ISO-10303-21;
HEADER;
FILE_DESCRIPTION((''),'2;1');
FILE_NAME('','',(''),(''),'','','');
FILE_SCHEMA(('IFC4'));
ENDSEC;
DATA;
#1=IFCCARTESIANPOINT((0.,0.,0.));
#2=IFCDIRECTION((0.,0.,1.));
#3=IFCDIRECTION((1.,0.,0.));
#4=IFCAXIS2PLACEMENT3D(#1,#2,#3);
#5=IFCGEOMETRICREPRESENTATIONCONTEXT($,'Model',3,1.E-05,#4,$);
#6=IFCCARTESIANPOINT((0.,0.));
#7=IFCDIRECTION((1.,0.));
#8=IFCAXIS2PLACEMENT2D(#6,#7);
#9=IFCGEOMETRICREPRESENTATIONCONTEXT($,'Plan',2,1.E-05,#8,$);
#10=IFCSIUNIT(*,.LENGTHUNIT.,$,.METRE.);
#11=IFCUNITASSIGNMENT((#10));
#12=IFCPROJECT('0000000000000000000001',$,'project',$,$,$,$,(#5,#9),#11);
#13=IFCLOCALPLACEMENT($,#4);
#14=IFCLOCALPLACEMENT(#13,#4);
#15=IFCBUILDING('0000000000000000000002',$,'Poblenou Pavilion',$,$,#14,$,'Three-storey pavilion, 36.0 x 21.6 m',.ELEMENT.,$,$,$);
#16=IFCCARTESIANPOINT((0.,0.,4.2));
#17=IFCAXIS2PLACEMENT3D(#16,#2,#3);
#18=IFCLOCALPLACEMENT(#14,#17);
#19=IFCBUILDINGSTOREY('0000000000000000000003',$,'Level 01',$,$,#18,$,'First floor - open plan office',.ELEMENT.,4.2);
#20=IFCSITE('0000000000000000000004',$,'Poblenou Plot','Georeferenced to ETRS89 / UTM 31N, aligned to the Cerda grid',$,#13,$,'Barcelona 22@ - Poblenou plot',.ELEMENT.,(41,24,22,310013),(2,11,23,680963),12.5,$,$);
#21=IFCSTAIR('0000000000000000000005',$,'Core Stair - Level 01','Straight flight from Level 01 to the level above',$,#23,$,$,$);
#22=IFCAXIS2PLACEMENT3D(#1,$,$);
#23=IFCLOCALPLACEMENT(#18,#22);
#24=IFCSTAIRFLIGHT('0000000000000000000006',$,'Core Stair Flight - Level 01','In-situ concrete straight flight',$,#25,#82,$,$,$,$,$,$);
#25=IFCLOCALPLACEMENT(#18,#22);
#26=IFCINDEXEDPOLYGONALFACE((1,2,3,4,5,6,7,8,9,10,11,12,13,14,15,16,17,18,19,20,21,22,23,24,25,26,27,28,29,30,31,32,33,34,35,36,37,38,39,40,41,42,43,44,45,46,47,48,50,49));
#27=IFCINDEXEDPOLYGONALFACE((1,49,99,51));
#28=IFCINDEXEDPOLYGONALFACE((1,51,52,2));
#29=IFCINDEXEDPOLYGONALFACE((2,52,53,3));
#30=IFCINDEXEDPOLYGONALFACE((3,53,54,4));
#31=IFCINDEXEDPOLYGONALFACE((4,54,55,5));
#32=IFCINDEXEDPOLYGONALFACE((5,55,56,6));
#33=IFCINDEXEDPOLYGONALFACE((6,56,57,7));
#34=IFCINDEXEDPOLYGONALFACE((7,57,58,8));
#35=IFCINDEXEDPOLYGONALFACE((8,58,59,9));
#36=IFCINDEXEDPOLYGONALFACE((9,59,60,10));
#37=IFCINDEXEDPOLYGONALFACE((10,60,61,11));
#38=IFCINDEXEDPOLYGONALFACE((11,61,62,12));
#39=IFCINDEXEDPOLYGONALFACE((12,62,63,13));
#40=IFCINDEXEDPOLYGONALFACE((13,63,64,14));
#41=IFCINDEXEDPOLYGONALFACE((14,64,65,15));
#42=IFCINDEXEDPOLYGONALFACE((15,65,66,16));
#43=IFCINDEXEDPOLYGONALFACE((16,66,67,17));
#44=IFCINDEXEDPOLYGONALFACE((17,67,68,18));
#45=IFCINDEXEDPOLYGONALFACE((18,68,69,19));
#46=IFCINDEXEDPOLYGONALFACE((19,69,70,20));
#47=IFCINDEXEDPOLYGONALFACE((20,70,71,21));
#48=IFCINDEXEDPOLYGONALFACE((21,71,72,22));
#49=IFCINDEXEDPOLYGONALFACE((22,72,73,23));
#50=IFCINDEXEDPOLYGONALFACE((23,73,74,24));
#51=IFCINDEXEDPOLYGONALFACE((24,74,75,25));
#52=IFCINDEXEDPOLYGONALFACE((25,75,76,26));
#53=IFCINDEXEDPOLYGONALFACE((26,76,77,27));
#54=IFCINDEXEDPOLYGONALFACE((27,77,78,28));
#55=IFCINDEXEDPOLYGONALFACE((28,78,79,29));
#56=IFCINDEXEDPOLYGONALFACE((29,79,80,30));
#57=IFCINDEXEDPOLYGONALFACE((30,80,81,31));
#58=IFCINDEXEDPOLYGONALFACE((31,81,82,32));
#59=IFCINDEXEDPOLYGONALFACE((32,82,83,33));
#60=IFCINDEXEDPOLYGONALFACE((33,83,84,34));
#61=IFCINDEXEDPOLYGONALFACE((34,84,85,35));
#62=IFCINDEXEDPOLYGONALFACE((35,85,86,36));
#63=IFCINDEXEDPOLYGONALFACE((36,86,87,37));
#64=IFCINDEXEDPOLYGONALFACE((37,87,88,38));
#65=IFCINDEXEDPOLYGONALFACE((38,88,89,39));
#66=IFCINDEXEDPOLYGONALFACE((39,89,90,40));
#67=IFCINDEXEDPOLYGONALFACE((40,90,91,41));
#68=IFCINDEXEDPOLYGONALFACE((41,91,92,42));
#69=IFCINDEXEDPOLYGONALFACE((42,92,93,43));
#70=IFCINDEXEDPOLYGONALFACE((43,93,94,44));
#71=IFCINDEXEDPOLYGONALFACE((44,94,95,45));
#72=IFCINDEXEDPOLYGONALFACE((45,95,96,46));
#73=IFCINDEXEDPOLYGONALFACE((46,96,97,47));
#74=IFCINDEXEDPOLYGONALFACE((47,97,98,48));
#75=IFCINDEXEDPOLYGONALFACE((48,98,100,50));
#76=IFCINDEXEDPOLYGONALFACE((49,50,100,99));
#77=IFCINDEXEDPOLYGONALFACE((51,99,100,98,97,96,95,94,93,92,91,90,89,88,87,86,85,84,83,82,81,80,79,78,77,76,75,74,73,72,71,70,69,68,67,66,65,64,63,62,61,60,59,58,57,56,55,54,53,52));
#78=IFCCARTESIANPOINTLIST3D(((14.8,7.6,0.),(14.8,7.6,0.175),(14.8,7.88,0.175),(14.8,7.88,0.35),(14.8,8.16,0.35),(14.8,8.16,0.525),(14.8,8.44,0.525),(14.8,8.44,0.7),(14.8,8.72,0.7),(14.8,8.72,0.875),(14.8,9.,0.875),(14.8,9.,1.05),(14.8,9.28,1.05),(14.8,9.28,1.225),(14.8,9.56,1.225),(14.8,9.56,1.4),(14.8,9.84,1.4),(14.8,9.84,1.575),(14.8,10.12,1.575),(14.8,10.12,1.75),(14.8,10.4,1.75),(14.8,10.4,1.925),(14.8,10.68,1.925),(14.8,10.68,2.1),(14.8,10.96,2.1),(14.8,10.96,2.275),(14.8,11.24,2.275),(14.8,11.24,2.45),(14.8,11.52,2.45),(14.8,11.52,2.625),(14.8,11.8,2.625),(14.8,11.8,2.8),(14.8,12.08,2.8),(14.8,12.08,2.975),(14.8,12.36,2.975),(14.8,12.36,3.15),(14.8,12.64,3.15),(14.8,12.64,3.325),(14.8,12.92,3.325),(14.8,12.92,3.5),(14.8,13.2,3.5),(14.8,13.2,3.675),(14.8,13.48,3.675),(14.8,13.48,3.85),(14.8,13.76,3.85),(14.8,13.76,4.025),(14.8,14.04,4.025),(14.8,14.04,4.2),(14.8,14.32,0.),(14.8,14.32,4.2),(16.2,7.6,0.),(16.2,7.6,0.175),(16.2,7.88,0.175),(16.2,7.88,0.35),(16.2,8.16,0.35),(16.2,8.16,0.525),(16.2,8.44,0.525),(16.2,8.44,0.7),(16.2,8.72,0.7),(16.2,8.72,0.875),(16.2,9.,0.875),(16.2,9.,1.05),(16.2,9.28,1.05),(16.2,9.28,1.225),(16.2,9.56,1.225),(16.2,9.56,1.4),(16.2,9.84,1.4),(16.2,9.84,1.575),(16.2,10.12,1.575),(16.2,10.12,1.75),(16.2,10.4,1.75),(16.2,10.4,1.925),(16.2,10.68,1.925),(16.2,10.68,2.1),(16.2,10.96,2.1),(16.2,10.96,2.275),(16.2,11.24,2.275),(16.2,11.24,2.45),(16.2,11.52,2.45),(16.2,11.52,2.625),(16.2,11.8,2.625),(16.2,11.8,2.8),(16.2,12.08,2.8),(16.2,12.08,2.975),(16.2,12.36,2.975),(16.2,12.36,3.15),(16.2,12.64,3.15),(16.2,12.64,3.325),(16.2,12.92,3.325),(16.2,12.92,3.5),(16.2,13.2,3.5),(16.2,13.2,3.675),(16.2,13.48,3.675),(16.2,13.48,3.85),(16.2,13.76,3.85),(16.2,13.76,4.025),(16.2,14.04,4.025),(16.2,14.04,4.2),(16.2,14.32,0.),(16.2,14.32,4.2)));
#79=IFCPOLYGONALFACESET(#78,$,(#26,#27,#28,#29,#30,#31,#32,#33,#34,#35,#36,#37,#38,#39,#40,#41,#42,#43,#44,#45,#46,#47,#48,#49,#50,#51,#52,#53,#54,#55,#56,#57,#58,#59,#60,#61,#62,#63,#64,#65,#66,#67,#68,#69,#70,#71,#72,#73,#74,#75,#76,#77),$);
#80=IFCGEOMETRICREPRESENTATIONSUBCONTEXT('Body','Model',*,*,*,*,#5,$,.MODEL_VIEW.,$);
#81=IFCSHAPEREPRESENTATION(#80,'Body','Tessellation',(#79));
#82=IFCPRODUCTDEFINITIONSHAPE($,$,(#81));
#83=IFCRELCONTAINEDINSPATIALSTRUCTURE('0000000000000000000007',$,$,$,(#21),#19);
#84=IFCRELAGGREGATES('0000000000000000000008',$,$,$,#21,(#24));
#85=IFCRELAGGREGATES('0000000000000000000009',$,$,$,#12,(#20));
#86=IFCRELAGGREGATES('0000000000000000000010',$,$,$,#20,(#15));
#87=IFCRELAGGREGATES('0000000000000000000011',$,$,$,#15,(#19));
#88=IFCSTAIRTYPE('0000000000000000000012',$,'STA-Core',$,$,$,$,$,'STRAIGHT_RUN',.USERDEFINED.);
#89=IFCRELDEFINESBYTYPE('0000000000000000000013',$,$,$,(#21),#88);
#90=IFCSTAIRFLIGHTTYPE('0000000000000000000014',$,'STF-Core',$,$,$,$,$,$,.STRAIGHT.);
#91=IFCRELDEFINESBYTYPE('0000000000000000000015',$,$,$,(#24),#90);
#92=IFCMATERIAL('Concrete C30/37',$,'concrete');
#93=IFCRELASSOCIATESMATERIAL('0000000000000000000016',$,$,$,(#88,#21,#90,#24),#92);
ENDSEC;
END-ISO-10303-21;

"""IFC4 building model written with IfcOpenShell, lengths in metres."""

from ifc_helpers import new_model, si_unit, frame, origin_with_axes, origin_2d_with_axis, place, context, subcontext, project, spatial, line, indexed_curve, outline, extrude, material, type_object, element, aggregate, save


model = new_model("IFC4")

# Units and contexts
model_context = context("Model", 3, precision=1e-05, world=origin_with_axes())
plan_context = context("Plan", 2, precision=1e-05, world=origin_2d_with_axis())
body_context = subcontext(model_context, "Body", "Model", "MODEL_VIEW")
ifc_project = project(units=[si_unit("LENGTHUNIT", "METRE")], contexts=[model_context, plan_context])

# Site, building, storey
site_placement = place(None, origin_with_axes())
site = spatial("IfcSite", under=ifc_project, at=site_placement, Name="Poblenou Plot", Description="Georeferenced to ETRS89 / UTM 31N, aligned to the Cerda grid", LongName="Barcelona 22@ - Poblenou plot", CompositionType="ELEMENT", RefLatitude=(41, 24, 22, 310013), RefLongitude=(2, 11, 23, 680963), RefElevation=12.5)
building_placement = place(site_placement, origin_with_axes())
building = spatial("IfcBuilding", under=site, at=building_placement, Name="Poblenou Pavilion", LongName="Three-storey pavilion, 36.0 x 21.6 m", CompositionType="ELEMENT")
storey_placement = place(building_placement, frame((0.0, 0.0, 4.2), z_axis=(0.0, 0.0, 1.0), x_axis=(1.0, 0.0, 0.0)))
storey = spatial("IfcBuildingStorey", under=building, at=storey_placement, Name="Level 01", LongName="First floor - open plan office", CompositionType="ELEMENT", Elevation=4.2)

# Stair, stair flight
ifc_material_1 = material(Name="Concrete C30/37", Category="concrete")
stair_type = type_object("IfcStairType", Name="STA-Core", ElementType="STRAIGHT_RUN", PredefinedType="USERDEFINED", material=ifc_material_1)
stair_placement = place(storey_placement, frame((14.8, 7.6, 0.0), z_axis=(0.0, 0.0, 1.0), x_axis=(1.0, 0.0, 0.0)))
stair = element("IfcStair", 1, at=stair_placement, inside=storey, type_object=stair_type, material=ifc_material_1, Name="Core Stair - Level 01", Description="Straight flight from Level 01 to the level above")
stair_flight_type = type_object("IfcStairFlightType", Name="STF-Core", PredefinedType="STRAIGHT", material=ifc_material_1)
stair_flight_placement = place(stair_placement, frame((0.0, 0.0, 0.0), z_axis=(1.0, 0.0, 0.0), x_axis=(0.0, 1.0, 0.0)))
stair_flight = element("IfcStairFlight", 2, at=stair_flight_placement, type_object=stair_flight_type, material=ifc_material_1, Name="Core Stair Flight - Level 01", Description="In-situ concrete straight flight", context=body_context, shape_type="SweptSolid", body=[
    extrude(outline(indexed_curve([(0.0, 0.0), (6.72, 0.0), (6.72, 4.2), (6.44, 4.2), (6.44, 4.025), (6.16, 4.025), (6.16, 3.85), (5.88, 3.85), (5.88, 3.675), (5.6, 3.675), (5.6, 3.5), (5.32, 3.5), (5.32, 3.325), (5.04, 3.325), (5.04, 3.15), (4.76, 3.15), (4.76, 2.975), (4.48, 2.975), (4.48, 2.8), (4.2, 2.8), (4.2, 2.625), (3.92, 2.625), (3.92, 2.45), (3.64, 2.45), (3.64, 2.275), (3.36, 2.275), (3.36, 2.1), (3.08, 2.1), (3.08, 1.925), (2.8, 1.925), (2.8, 1.75), (2.52, 1.75), (2.52, 1.575), (2.24, 1.575), (2.24, 1.4), (1.96, 1.4), (1.96, 1.225), (1.68, 1.225), (1.68, 1.05), (1.4, 1.05), (1.4, 0.875), (1.12, 0.875), (1.12, 0.7), (0.84, 0.7), (0.84, 0.525), (0.56, 0.525), (0.56, 0.35), (0.28, 0.35), (0.28, 0.175), (0.0, 0.175)], segments=[line(1, 2, 3, 4, 5, 6, 7, 8, 9, 10, 11, 12, 13, 14, 15, 16, 17, 18, 19, 20, 21, 22, 23, 24, 25, 26, 27, 28, 29, 30, 31, 32, 33, 34, 35, 36, 37, 38, 39, 40, 41, 42, 43, 44, 45, 46, 47, 48, 49, 50, 1)])), origin_with_axes(), (0.0, 0.0, 1.0), 1.4),
])
aggregate(stair, [stair_flight])

save(model, "model.ifc")
